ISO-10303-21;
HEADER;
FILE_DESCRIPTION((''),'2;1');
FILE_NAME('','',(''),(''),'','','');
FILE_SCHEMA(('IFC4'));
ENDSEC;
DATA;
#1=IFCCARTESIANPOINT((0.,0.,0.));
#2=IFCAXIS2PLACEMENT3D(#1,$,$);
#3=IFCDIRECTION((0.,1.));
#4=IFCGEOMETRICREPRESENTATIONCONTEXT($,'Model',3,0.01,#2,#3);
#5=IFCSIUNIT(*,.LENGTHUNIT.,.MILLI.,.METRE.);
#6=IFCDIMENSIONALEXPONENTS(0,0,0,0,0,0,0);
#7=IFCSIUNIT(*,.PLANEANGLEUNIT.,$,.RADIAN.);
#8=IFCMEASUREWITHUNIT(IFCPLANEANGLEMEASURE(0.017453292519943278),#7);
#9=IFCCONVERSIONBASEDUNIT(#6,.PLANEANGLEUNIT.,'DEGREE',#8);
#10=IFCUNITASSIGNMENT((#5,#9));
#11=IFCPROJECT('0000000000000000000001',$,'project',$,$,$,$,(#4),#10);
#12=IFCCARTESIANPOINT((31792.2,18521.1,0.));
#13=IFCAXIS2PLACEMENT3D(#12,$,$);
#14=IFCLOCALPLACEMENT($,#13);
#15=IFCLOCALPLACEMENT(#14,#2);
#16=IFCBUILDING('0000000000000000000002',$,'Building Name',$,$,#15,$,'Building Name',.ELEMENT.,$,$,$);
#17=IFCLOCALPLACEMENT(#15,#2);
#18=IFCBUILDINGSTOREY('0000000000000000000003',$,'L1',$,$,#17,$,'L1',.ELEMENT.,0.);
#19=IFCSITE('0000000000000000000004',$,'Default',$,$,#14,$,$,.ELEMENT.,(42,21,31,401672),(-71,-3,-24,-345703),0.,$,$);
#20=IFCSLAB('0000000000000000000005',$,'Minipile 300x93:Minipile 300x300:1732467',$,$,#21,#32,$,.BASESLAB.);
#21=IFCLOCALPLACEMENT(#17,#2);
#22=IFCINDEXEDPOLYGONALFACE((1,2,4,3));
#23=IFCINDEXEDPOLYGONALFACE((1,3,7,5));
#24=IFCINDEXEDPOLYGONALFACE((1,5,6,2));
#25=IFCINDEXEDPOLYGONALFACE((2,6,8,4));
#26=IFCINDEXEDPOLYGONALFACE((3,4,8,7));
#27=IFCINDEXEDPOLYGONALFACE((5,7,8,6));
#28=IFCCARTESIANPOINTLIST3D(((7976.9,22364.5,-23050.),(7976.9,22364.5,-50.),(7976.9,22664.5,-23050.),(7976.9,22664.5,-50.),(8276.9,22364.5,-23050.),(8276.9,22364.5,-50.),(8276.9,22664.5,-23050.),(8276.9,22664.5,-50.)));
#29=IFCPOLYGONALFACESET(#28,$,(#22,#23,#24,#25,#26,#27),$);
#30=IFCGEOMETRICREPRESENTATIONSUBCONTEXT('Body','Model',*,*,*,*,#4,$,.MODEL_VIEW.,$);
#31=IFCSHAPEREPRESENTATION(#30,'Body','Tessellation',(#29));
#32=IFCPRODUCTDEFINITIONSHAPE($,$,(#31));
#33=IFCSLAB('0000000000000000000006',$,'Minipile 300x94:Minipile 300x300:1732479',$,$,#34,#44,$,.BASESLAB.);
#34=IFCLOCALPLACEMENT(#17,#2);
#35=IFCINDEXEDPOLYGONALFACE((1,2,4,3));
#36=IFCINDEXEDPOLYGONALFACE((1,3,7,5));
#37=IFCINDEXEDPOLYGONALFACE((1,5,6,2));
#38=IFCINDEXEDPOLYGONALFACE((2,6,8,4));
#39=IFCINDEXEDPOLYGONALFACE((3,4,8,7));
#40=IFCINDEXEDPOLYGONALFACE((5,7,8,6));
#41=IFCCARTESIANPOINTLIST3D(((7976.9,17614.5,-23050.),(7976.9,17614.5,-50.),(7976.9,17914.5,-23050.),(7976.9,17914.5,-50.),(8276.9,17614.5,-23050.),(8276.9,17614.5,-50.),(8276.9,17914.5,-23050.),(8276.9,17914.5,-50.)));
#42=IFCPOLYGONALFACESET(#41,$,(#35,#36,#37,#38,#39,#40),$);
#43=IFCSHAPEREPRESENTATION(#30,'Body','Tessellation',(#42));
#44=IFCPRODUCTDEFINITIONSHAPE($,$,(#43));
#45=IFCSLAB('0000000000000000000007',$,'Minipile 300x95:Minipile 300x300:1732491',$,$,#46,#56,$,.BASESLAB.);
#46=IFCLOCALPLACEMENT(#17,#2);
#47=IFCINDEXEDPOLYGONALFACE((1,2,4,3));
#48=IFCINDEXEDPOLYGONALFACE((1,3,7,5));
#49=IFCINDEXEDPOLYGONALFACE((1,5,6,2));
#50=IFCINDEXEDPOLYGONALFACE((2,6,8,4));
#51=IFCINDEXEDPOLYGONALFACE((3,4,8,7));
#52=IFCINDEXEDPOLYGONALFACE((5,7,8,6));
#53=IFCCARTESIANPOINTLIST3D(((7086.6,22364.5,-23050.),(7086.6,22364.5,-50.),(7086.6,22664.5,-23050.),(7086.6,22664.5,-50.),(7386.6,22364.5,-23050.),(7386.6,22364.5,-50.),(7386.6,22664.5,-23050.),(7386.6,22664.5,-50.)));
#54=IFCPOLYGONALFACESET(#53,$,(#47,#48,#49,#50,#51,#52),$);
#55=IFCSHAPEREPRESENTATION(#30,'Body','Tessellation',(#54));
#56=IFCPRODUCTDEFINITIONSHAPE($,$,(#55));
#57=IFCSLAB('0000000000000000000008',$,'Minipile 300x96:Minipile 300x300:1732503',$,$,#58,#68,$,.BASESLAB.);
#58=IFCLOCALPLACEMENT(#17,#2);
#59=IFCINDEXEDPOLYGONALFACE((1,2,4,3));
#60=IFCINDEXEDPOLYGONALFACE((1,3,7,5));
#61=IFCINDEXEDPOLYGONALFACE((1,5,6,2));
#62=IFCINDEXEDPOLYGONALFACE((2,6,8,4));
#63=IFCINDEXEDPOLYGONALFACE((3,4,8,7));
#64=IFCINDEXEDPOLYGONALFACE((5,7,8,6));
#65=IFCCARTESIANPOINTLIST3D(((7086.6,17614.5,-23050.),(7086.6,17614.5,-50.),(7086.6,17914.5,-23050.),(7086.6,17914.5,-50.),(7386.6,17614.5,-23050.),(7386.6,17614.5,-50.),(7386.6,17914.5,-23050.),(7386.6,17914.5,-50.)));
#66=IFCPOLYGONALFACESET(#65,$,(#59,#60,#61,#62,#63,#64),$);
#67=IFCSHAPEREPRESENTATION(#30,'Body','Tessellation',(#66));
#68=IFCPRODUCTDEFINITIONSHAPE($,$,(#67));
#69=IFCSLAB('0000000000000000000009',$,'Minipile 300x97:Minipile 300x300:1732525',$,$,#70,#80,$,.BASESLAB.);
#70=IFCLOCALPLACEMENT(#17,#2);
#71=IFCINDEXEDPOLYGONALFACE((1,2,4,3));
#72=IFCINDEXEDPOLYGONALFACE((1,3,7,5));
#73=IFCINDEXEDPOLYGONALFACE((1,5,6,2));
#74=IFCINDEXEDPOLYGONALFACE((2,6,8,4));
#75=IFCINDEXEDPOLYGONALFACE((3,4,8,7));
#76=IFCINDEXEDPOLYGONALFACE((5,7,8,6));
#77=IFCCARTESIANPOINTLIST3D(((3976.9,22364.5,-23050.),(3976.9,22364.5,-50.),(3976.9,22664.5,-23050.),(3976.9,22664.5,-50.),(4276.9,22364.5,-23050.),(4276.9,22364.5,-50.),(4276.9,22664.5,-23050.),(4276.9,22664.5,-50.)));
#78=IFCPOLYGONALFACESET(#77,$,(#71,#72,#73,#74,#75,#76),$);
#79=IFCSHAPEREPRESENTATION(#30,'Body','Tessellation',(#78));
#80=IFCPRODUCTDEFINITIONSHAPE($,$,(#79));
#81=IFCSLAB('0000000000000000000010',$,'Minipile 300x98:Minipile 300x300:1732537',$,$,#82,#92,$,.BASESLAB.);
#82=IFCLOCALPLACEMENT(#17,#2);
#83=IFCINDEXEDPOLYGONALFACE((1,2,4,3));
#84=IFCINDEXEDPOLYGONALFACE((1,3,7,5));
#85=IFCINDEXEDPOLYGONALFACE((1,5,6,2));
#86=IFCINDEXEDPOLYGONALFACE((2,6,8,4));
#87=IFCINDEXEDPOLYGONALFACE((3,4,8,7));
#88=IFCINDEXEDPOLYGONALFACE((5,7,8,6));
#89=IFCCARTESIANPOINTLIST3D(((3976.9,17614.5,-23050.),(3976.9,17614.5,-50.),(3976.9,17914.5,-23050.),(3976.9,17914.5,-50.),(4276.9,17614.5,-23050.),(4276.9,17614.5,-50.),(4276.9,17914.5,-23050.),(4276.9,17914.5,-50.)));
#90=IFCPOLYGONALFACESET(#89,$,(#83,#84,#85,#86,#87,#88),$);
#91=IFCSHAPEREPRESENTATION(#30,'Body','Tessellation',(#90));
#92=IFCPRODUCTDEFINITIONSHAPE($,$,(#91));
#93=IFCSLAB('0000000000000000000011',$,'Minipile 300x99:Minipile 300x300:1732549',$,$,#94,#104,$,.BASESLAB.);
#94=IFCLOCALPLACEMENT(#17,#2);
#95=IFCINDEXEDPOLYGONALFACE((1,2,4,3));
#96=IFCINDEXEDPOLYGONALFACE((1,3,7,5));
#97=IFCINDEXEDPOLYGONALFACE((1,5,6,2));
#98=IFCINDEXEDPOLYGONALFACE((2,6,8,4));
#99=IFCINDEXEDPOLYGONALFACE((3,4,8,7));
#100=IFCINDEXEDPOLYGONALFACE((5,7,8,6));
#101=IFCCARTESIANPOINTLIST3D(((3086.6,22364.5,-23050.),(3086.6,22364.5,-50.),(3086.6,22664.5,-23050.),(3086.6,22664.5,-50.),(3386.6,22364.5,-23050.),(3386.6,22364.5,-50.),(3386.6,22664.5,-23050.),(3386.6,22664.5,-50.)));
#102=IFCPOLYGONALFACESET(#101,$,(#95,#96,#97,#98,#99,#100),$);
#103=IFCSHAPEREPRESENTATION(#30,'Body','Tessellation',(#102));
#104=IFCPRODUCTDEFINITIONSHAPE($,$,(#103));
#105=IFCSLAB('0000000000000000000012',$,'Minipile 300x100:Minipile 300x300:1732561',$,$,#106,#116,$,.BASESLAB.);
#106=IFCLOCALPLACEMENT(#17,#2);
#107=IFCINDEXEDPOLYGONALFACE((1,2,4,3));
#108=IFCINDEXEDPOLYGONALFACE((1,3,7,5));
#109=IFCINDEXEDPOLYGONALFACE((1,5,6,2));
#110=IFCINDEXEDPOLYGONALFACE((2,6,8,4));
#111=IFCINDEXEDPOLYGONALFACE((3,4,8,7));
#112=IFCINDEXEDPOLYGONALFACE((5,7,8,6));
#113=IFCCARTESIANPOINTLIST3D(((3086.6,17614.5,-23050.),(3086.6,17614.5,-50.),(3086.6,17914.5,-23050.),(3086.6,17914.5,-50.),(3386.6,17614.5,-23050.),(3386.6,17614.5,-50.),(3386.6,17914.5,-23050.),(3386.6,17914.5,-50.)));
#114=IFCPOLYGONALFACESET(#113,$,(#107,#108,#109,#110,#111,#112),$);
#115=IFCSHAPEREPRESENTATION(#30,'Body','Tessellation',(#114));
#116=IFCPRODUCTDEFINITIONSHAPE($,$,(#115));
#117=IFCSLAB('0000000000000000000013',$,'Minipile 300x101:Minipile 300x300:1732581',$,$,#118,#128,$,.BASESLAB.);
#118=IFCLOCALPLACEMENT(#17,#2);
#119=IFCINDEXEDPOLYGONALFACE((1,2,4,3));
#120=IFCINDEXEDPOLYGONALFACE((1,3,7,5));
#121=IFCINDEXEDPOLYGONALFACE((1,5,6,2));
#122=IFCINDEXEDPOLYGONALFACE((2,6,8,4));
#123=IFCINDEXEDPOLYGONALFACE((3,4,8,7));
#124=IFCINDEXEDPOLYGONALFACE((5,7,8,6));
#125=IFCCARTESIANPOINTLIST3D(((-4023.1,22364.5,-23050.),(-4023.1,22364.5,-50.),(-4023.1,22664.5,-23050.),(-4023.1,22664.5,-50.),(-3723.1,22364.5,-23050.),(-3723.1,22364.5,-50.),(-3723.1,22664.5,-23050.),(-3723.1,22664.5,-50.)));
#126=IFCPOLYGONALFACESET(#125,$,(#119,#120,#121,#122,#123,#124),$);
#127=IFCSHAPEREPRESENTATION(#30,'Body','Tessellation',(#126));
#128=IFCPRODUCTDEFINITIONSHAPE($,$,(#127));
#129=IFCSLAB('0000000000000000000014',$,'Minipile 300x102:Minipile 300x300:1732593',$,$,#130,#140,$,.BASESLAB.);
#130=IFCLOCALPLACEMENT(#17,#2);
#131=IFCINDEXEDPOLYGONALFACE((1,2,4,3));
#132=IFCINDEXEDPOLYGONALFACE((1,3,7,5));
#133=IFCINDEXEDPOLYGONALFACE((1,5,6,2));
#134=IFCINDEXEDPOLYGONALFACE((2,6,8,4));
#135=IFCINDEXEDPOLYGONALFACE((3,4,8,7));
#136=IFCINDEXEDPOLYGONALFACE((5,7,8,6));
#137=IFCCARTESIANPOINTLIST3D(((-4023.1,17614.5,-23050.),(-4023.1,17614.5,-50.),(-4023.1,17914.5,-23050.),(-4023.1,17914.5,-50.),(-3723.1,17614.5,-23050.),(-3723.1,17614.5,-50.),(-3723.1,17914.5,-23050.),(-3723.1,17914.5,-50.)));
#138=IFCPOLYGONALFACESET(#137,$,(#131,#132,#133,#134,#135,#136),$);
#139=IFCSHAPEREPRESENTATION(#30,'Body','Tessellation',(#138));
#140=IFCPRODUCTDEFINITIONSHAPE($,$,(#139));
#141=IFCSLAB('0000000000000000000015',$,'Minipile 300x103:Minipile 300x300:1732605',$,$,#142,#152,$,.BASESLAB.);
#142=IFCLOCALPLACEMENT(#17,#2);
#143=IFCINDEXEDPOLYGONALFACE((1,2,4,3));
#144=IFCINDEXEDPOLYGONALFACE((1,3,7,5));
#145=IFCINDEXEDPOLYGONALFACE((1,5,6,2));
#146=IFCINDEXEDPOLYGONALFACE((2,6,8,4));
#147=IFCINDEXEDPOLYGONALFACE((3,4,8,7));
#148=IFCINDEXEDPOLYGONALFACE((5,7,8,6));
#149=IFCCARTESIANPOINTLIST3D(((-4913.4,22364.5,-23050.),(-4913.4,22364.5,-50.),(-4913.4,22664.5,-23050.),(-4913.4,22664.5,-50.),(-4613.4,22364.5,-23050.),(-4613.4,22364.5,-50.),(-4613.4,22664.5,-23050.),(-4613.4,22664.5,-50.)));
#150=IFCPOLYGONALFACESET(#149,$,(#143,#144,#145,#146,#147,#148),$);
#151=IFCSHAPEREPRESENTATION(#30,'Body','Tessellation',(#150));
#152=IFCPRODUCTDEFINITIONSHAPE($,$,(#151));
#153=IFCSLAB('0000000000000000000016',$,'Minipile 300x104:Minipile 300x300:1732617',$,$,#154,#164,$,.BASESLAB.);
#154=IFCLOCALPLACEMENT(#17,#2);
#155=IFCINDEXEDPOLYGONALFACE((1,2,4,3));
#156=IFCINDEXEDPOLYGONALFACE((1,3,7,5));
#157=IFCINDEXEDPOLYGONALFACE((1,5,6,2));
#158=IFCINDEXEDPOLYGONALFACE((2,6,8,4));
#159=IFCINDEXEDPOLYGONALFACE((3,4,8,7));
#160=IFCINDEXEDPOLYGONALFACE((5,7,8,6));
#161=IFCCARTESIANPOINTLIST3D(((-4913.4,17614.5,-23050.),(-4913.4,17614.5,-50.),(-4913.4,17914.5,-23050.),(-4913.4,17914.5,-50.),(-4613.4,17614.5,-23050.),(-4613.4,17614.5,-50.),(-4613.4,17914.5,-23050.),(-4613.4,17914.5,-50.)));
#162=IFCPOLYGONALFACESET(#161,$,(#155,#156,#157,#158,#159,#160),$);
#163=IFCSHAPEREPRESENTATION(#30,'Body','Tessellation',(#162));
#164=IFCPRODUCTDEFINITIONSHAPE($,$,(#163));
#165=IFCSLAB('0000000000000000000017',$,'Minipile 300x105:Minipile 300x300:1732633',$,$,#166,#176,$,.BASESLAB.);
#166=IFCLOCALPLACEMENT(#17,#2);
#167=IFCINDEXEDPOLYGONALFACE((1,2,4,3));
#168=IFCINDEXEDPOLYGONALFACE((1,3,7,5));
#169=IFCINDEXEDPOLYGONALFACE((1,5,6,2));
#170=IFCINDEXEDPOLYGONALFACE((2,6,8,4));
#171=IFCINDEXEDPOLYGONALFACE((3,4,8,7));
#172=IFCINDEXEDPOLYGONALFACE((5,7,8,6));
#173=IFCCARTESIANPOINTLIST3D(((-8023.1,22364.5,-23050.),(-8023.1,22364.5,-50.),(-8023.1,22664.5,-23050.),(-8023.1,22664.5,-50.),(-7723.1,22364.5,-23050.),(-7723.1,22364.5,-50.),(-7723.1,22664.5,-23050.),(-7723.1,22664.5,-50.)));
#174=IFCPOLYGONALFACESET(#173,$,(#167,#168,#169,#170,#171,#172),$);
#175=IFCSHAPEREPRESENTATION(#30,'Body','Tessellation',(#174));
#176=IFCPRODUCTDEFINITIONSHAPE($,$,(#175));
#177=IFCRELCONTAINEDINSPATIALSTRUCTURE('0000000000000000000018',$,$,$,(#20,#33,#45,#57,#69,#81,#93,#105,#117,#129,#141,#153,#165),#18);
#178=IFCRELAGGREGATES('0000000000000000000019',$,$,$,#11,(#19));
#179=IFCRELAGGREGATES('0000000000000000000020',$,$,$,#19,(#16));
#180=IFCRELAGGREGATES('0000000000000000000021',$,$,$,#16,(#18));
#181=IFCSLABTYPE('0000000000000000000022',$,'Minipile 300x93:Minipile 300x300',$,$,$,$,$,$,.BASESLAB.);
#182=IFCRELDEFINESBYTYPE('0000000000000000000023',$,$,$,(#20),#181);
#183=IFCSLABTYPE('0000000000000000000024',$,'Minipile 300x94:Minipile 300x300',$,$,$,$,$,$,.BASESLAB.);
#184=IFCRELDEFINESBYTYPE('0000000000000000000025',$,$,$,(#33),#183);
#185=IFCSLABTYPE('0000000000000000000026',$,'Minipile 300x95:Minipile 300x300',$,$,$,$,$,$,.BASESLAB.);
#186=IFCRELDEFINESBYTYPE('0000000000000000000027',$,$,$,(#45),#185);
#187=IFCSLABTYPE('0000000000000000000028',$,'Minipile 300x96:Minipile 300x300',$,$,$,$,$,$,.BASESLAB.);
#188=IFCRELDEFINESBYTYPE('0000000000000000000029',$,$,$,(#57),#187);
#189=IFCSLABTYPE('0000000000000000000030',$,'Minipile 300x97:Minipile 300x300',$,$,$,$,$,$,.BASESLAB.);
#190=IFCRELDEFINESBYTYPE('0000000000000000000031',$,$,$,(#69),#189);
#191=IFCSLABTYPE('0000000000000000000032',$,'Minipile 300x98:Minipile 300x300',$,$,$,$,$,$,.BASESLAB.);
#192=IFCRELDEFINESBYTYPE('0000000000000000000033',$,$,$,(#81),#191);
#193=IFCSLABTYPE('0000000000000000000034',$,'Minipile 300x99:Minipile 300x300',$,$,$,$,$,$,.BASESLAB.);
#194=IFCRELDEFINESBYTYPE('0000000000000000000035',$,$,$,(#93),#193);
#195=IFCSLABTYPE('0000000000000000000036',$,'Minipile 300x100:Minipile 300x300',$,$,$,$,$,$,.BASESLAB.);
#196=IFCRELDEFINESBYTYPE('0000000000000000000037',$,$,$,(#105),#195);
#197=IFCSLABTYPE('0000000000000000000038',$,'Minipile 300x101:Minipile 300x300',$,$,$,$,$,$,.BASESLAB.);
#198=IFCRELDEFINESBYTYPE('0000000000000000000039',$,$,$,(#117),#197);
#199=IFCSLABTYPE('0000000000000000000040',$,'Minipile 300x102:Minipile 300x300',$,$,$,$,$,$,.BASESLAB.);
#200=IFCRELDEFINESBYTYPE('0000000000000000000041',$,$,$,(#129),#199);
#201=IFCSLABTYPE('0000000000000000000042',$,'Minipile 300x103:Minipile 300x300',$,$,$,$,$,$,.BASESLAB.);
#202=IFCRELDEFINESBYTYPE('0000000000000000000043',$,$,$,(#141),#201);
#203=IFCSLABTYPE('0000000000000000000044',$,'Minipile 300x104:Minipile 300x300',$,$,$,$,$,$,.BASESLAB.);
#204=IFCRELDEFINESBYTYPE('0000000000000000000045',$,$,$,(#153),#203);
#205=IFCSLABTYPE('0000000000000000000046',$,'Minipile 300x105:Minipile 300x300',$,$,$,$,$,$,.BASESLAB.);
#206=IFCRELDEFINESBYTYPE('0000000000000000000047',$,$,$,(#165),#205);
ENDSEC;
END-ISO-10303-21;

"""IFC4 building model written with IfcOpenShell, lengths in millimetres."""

from ifc_helpers import new_model, entity, si_unit, converted_unit, direction, frame, origin, place, context, subcontext, project, spatial, indexed_curve, outline, extrude, type_object, element, save


model = new_model("IFC4")

# Units and contexts
model_context = context("Model", 3, precision=0.01, world=origin(), true_north=direction((0.0, 1.0)))
body_context = subcontext(model_context, "Body", "Model", "MODEL_VIEW")
ifc_project = project(units=[si_unit("LENGTHUNIT", "METRE", prefix="MILLI"), converted_unit("PLANEANGLEUNIT", "DEGREE", entity("IfcPlaneAngleMeasure", 0.017453292519943278), si_unit("PLANEANGLEUNIT", "RADIAN"), dimensions=[0, 0, 0, 0, 0, 0, 0])], contexts=[model_context])

# Site, building, storey
site_placement = place(None, frame((31792.2, 18521.1, 0.0)))
site = spatial("IfcSite", under=ifc_project, at=site_placement, Name="Default", CompositionType="ELEMENT", RefLatitude=(42, 21, 31, 401672), RefLongitude=(-71, -3, -24, -345703), RefElevation=0.0)
building_placement = place(site_placement, origin())
building = spatial("IfcBuilding", under=site, at=building_placement, Name="Building Name", LongName="Building Name", CompositionType="ELEMENT")
storey_placement = place(building_placement, origin())
storey = spatial("IfcBuildingStorey", under=building, at=storey_placement, Name="L1", LongName="L1", CompositionType="ELEMENT", Elevation=0.0)

# Slabs
slab_type_1 = type_object("IfcSlabType", Name="Minipile 300x93:Minipile 300x300", PredefinedType="BASESLAB")
slab_1_placement = place(storey_placement, origin())
element("IfcSlab", 1, at=slab_1_placement, inside=storey, type_object=slab_type_1, Name="Minipile 300x93:Minipile 300x300:1732467", PredefinedType="BASESLAB", context=body_context, shape_type="SweptSolid", body=[
    extrude(outline(indexed_curve([(-150.0, -150.0), (150.0, -150.0), (150.0, 150.0), (-150.0, 150.0), (-150.0, -150.0)], self_intersect=False)), frame((8126.9, 22514.5, -23050.0), z_axis=(0.0, 0.0, 1.0), x_axis=(0.0, -1.0, 0.0)), (0.0, 0.0, 1.0), 23000.0),
])
slab_type_2 = type_object("IfcSlabType", Name="Minipile 300x94:Minipile 300x300", PredefinedType="BASESLAB")
slab_2_placement = place(storey_placement, origin())
element("IfcSlab", 2, at=slab_2_placement, inside=storey, type_object=slab_type_2, Name="Minipile 300x94:Minipile 300x300:1732479", PredefinedType="BASESLAB", context=body_context, shape_type="SweptSolid", body=[
    extrude(outline(indexed_curve([(-150.0, -150.0), (150.0, -150.0), (150.0, 150.0), (-150.0, 150.0), (-150.0, -150.0)], self_intersect=False)), frame((8126.9, 17764.5, -23050.0), z_axis=(0.0, 0.0, 1.0), x_axis=(0.0, -1.0, 0.0)), (0.0, 0.0, 1.0), 23000.0),
])
slab_type_3 = type_object("IfcSlabType", Name="Minipile 300x95:Minipile 300x300", PredefinedType="BASESLAB")
slab_3_placement = place(storey_placement, origin())
element("IfcSlab", 3, at=slab_3_placement, inside=storey, type_object=slab_type_3, Name="Minipile 300x95:Minipile 300x300:1732491", PredefinedType="BASESLAB", context=body_context, shape_type="SweptSolid", body=[
    extrude(outline(indexed_curve([(-150.0, -150.0), (150.0, -150.0), (150.0, 150.0), (-150.0, 150.0), (-150.0, -150.0)], self_intersect=False)), frame((7236.6, 22514.5, -23050.0), z_axis=(0.0, 0.0, 1.0), x_axis=(0.0, -1.0, 0.0)), (0.0, 0.0, 1.0), 23000.0),
])
slab_type_4 = type_object("IfcSlabType", Name="Minipile 300x96:Minipile 300x300", PredefinedType="BASESLAB")
slab_4_placement = place(storey_placement, origin())
element("IfcSlab", 4, at=slab_4_placement, inside=storey, type_object=slab_type_4, Name="Minipile 300x96:Minipile 300x300:1732503", PredefinedType="BASESLAB", context=body_context, shape_type="SweptSolid", body=[
    extrude(outline(indexed_curve([(-150.0, -150.0), (150.0, -150.0), (150.0, 150.0), (-150.0, 150.0), (-150.0, -150.0)], self_intersect=False)), frame((7236.6, 17764.5, -23050.0), z_axis=(0.0, 0.0, 1.0), x_axis=(0.0, -1.0, 0.0)), (0.0, 0.0, 1.0), 23000.0),
])
slab_type_5 = type_object("IfcSlabType", Name="Minipile 300x97:Minipile 300x300", PredefinedType="BASESLAB")
slab_5_placement = place(storey_placement, origin())
element("IfcSlab", 5, at=slab_5_placement, inside=storey, type_object=slab_type_5, Name="Minipile 300x97:Minipile 300x300:1732525", PredefinedType="BASESLAB", context=body_context, shape_type="SweptSolid", body=[
    extrude(outline(indexed_curve([(-150.0, -150.0), (150.0, -150.0), (150.0, 150.0), (-150.0, 150.0), (-150.0, -150.0)], self_intersect=False)), frame((4126.9, 22514.5, -23050.0), z_axis=(0.0, 0.0, 1.0), x_axis=(0.0, -1.0, 0.0)), (0.0, 0.0, 1.0), 23000.0),
])
slab_type_6 = type_object("IfcSlabType", Name="Minipile 300x98:Minipile 300x300", PredefinedType="BASESLAB")
slab_6_placement = place(storey_placement, origin())
element("IfcSlab", 6, at=slab_6_placement, inside=storey, type_object=slab_type_6, Name="Minipile 300x98:Minipile 300x300:1732537", PredefinedType="BASESLAB", context=body_context, shape_type="SweptSolid", body=[
    extrude(outline(indexed_curve([(-150.0, -150.0), (150.0, -150.0), (150.0, 150.0), (-150.0, 150.0), (-150.0, -150.0)], self_intersect=False)), frame((4126.9, 17764.5, -23050.0), z_axis=(0.0, 0.0, 1.0), x_axis=(0.0, -1.0, 0.0)), (0.0, 0.0, 1.0), 23000.0),
])
slab_type_7 = type_object("IfcSlabType", Name="Minipile 300x99:Minipile 300x300", PredefinedType="BASESLAB")
slab_7_placement = place(storey_placement, origin())
element("IfcSlab", 7, at=slab_7_placement, inside=storey, type_object=slab_type_7, Name="Minipile 300x99:Minipile 300x300:1732549", PredefinedType="BASESLAB", context=body_context, shape_type="SweptSolid", body=[
    extrude(outline(indexed_curve([(-150.0, -150.0), (150.0, -150.0), (150.0, 150.0), (-150.0, 150.0), (-150.0, -150.0)], self_intersect=False)), frame((3236.6, 22514.5, -23050.0), z_axis=(0.0, 0.0, 1.0), x_axis=(0.0, -1.0, 0.0)), (0.0, 0.0, 1.0), 23000.0),
])
slab_type_8 = type_object("IfcSlabType", Name="Minipile 300x100:Minipile 300x300", PredefinedType="BASESLAB")
slab_8_placement = place(storey_placement, origin())
element("IfcSlab", 8, at=slab_8_placement, inside=storey, type_object=slab_type_8, Name="Minipile 300x100:Minipile 300x300:1732561", PredefinedType="BASESLAB", context=body_context, shape_type="SweptSolid", body=[
    extrude(outline(indexed_curve([(-150.0, -150.0), (150.0, -150.0), (150.0, 150.0), (-150.0, 150.0), (-150.0, -150.0)], self_intersect=False)), frame((3236.6, 17764.5, -23050.0), z_axis=(0.0, 0.0, 1.0), x_axis=(0.0, -1.0, 0.0)), (0.0, 0.0, 1.0), 23000.0),
])
slab_type_9 = type_object("IfcSlabType", Name="Minipile 300x101:Minipile 300x300", PredefinedType="BASESLAB")
slab_9_placement = place(storey_placement, origin())
element("IfcSlab", 9, at=slab_9_placement, inside=storey, type_object=slab_type_9, Name="Minipile 300x101:Minipile 300x300:1732581", PredefinedType="BASESLAB", context=body_context, shape_type="SweptSolid", body=[
    extrude(outline(indexed_curve([(-150.0, -150.0), (150.0, -150.0), (150.0, 150.0), (-150.0, 150.0), (-150.0, -150.0)], self_intersect=False)), frame((-3873.1, 22514.5, -23050.0), z_axis=(0.0, 0.0, 1.0), x_axis=(0.0, -1.0, 0.0)), (0.0, 0.0, 1.0), 23000.0),
])
slab_type_10 = type_object("IfcSlabType", Name="Minipile 300x102:Minipile 300x300", PredefinedType="BASESLAB")
slab_10_placement = place(storey_placement, origin())
element("IfcSlab", 10, at=slab_10_placement, inside=storey, type_object=slab_type_10, Name="Minipile 300x102:Minipile 300x300:1732593", PredefinedType="BASESLAB", context=body_context, shape_type="SweptSolid", body=[
    extrude(outline(indexed_curve([(-150.0, -150.0), (150.0, -150.0), (150.0, 150.0), (-150.0, 150.0), (-150.0, -150.0)], self_intersect=False)), frame((-3873.1, 17764.5, -23050.0), z_axis=(0.0, 0.0, 1.0), x_axis=(0.0, -1.0, 0.0)), (0.0, 0.0, 1.0), 23000.0),
])
slab_type_11 = type_object("IfcSlabType", Name="Minipile 300x103:Minipile 300x300", PredefinedType="BASESLAB")
slab_11_placement = place(storey_placement, origin())
element("IfcSlab", 11, at=slab_11_placement, inside=storey, type_object=slab_type_11, Name="Minipile 300x103:Minipile 300x300:1732605", PredefinedType="BASESLAB", context=body_context, shape_type="SweptSolid", body=[
    extrude(outline(indexed_curve([(-150.0, -150.0), (150.0, -150.0), (150.0, 150.0), (-150.0, 150.0), (-150.0, -150.0)], self_intersect=False)), frame((-4763.4, 22514.5, -23050.0), z_axis=(0.0, 0.0, 1.0), x_axis=(0.0, -1.0, 0.0)), (0.0, 0.0, 1.0), 23000.0),
])
slab_type_12 = type_object("IfcSlabType", Name="Minipile 300x104:Minipile 300x300", PredefinedType="BASESLAB")
slab_12_placement = place(storey_placement, origin())
element("IfcSlab", 12, at=slab_12_placement, inside=storey, type_object=slab_type_12, Name="Minipile 300x104:Minipile 300x300:1732617", PredefinedType="BASESLAB", context=body_context, shape_type="SweptSolid", body=[
    extrude(outline(indexed_curve([(-150.0, -150.0), (150.0, -150.0), (150.0, 150.0), (-150.0, 150.0), (-150.0, -150.0)], self_intersect=False)), frame((-4763.4, 17764.5, -23050.0), z_axis=(0.0, 0.0, 1.0), x_axis=(0.0, -1.0, 0.0)), (0.0, 0.0, 1.0), 23000.0),
])
slab_type_13 = type_object("IfcSlabType", Name="Minipile 300x105:Minipile 300x300", PredefinedType="BASESLAB")
slab_13_placement = place(storey_placement, origin())
element("IfcSlab", 13, at=slab_13_placement, inside=storey, type_object=slab_type_13, Name="Minipile 300x105:Minipile 300x300:1732633", PredefinedType="BASESLAB", context=body_context, shape_type="SweptSolid", body=[
    extrude(outline(indexed_curve([(-150.0, -150.0), (150.0, -150.0), (150.0, 150.0), (-150.0, 150.0), (-150.0, -150.0)], self_intersect=False)), frame((-7873.1, 22514.5, -23050.0), z_axis=(0.0, 0.0, 1.0), x_axis=(0.0, -1.0, 0.0)), (0.0, 0.0, 1.0), 23000.0),
])

save(model, "model.ifc")
